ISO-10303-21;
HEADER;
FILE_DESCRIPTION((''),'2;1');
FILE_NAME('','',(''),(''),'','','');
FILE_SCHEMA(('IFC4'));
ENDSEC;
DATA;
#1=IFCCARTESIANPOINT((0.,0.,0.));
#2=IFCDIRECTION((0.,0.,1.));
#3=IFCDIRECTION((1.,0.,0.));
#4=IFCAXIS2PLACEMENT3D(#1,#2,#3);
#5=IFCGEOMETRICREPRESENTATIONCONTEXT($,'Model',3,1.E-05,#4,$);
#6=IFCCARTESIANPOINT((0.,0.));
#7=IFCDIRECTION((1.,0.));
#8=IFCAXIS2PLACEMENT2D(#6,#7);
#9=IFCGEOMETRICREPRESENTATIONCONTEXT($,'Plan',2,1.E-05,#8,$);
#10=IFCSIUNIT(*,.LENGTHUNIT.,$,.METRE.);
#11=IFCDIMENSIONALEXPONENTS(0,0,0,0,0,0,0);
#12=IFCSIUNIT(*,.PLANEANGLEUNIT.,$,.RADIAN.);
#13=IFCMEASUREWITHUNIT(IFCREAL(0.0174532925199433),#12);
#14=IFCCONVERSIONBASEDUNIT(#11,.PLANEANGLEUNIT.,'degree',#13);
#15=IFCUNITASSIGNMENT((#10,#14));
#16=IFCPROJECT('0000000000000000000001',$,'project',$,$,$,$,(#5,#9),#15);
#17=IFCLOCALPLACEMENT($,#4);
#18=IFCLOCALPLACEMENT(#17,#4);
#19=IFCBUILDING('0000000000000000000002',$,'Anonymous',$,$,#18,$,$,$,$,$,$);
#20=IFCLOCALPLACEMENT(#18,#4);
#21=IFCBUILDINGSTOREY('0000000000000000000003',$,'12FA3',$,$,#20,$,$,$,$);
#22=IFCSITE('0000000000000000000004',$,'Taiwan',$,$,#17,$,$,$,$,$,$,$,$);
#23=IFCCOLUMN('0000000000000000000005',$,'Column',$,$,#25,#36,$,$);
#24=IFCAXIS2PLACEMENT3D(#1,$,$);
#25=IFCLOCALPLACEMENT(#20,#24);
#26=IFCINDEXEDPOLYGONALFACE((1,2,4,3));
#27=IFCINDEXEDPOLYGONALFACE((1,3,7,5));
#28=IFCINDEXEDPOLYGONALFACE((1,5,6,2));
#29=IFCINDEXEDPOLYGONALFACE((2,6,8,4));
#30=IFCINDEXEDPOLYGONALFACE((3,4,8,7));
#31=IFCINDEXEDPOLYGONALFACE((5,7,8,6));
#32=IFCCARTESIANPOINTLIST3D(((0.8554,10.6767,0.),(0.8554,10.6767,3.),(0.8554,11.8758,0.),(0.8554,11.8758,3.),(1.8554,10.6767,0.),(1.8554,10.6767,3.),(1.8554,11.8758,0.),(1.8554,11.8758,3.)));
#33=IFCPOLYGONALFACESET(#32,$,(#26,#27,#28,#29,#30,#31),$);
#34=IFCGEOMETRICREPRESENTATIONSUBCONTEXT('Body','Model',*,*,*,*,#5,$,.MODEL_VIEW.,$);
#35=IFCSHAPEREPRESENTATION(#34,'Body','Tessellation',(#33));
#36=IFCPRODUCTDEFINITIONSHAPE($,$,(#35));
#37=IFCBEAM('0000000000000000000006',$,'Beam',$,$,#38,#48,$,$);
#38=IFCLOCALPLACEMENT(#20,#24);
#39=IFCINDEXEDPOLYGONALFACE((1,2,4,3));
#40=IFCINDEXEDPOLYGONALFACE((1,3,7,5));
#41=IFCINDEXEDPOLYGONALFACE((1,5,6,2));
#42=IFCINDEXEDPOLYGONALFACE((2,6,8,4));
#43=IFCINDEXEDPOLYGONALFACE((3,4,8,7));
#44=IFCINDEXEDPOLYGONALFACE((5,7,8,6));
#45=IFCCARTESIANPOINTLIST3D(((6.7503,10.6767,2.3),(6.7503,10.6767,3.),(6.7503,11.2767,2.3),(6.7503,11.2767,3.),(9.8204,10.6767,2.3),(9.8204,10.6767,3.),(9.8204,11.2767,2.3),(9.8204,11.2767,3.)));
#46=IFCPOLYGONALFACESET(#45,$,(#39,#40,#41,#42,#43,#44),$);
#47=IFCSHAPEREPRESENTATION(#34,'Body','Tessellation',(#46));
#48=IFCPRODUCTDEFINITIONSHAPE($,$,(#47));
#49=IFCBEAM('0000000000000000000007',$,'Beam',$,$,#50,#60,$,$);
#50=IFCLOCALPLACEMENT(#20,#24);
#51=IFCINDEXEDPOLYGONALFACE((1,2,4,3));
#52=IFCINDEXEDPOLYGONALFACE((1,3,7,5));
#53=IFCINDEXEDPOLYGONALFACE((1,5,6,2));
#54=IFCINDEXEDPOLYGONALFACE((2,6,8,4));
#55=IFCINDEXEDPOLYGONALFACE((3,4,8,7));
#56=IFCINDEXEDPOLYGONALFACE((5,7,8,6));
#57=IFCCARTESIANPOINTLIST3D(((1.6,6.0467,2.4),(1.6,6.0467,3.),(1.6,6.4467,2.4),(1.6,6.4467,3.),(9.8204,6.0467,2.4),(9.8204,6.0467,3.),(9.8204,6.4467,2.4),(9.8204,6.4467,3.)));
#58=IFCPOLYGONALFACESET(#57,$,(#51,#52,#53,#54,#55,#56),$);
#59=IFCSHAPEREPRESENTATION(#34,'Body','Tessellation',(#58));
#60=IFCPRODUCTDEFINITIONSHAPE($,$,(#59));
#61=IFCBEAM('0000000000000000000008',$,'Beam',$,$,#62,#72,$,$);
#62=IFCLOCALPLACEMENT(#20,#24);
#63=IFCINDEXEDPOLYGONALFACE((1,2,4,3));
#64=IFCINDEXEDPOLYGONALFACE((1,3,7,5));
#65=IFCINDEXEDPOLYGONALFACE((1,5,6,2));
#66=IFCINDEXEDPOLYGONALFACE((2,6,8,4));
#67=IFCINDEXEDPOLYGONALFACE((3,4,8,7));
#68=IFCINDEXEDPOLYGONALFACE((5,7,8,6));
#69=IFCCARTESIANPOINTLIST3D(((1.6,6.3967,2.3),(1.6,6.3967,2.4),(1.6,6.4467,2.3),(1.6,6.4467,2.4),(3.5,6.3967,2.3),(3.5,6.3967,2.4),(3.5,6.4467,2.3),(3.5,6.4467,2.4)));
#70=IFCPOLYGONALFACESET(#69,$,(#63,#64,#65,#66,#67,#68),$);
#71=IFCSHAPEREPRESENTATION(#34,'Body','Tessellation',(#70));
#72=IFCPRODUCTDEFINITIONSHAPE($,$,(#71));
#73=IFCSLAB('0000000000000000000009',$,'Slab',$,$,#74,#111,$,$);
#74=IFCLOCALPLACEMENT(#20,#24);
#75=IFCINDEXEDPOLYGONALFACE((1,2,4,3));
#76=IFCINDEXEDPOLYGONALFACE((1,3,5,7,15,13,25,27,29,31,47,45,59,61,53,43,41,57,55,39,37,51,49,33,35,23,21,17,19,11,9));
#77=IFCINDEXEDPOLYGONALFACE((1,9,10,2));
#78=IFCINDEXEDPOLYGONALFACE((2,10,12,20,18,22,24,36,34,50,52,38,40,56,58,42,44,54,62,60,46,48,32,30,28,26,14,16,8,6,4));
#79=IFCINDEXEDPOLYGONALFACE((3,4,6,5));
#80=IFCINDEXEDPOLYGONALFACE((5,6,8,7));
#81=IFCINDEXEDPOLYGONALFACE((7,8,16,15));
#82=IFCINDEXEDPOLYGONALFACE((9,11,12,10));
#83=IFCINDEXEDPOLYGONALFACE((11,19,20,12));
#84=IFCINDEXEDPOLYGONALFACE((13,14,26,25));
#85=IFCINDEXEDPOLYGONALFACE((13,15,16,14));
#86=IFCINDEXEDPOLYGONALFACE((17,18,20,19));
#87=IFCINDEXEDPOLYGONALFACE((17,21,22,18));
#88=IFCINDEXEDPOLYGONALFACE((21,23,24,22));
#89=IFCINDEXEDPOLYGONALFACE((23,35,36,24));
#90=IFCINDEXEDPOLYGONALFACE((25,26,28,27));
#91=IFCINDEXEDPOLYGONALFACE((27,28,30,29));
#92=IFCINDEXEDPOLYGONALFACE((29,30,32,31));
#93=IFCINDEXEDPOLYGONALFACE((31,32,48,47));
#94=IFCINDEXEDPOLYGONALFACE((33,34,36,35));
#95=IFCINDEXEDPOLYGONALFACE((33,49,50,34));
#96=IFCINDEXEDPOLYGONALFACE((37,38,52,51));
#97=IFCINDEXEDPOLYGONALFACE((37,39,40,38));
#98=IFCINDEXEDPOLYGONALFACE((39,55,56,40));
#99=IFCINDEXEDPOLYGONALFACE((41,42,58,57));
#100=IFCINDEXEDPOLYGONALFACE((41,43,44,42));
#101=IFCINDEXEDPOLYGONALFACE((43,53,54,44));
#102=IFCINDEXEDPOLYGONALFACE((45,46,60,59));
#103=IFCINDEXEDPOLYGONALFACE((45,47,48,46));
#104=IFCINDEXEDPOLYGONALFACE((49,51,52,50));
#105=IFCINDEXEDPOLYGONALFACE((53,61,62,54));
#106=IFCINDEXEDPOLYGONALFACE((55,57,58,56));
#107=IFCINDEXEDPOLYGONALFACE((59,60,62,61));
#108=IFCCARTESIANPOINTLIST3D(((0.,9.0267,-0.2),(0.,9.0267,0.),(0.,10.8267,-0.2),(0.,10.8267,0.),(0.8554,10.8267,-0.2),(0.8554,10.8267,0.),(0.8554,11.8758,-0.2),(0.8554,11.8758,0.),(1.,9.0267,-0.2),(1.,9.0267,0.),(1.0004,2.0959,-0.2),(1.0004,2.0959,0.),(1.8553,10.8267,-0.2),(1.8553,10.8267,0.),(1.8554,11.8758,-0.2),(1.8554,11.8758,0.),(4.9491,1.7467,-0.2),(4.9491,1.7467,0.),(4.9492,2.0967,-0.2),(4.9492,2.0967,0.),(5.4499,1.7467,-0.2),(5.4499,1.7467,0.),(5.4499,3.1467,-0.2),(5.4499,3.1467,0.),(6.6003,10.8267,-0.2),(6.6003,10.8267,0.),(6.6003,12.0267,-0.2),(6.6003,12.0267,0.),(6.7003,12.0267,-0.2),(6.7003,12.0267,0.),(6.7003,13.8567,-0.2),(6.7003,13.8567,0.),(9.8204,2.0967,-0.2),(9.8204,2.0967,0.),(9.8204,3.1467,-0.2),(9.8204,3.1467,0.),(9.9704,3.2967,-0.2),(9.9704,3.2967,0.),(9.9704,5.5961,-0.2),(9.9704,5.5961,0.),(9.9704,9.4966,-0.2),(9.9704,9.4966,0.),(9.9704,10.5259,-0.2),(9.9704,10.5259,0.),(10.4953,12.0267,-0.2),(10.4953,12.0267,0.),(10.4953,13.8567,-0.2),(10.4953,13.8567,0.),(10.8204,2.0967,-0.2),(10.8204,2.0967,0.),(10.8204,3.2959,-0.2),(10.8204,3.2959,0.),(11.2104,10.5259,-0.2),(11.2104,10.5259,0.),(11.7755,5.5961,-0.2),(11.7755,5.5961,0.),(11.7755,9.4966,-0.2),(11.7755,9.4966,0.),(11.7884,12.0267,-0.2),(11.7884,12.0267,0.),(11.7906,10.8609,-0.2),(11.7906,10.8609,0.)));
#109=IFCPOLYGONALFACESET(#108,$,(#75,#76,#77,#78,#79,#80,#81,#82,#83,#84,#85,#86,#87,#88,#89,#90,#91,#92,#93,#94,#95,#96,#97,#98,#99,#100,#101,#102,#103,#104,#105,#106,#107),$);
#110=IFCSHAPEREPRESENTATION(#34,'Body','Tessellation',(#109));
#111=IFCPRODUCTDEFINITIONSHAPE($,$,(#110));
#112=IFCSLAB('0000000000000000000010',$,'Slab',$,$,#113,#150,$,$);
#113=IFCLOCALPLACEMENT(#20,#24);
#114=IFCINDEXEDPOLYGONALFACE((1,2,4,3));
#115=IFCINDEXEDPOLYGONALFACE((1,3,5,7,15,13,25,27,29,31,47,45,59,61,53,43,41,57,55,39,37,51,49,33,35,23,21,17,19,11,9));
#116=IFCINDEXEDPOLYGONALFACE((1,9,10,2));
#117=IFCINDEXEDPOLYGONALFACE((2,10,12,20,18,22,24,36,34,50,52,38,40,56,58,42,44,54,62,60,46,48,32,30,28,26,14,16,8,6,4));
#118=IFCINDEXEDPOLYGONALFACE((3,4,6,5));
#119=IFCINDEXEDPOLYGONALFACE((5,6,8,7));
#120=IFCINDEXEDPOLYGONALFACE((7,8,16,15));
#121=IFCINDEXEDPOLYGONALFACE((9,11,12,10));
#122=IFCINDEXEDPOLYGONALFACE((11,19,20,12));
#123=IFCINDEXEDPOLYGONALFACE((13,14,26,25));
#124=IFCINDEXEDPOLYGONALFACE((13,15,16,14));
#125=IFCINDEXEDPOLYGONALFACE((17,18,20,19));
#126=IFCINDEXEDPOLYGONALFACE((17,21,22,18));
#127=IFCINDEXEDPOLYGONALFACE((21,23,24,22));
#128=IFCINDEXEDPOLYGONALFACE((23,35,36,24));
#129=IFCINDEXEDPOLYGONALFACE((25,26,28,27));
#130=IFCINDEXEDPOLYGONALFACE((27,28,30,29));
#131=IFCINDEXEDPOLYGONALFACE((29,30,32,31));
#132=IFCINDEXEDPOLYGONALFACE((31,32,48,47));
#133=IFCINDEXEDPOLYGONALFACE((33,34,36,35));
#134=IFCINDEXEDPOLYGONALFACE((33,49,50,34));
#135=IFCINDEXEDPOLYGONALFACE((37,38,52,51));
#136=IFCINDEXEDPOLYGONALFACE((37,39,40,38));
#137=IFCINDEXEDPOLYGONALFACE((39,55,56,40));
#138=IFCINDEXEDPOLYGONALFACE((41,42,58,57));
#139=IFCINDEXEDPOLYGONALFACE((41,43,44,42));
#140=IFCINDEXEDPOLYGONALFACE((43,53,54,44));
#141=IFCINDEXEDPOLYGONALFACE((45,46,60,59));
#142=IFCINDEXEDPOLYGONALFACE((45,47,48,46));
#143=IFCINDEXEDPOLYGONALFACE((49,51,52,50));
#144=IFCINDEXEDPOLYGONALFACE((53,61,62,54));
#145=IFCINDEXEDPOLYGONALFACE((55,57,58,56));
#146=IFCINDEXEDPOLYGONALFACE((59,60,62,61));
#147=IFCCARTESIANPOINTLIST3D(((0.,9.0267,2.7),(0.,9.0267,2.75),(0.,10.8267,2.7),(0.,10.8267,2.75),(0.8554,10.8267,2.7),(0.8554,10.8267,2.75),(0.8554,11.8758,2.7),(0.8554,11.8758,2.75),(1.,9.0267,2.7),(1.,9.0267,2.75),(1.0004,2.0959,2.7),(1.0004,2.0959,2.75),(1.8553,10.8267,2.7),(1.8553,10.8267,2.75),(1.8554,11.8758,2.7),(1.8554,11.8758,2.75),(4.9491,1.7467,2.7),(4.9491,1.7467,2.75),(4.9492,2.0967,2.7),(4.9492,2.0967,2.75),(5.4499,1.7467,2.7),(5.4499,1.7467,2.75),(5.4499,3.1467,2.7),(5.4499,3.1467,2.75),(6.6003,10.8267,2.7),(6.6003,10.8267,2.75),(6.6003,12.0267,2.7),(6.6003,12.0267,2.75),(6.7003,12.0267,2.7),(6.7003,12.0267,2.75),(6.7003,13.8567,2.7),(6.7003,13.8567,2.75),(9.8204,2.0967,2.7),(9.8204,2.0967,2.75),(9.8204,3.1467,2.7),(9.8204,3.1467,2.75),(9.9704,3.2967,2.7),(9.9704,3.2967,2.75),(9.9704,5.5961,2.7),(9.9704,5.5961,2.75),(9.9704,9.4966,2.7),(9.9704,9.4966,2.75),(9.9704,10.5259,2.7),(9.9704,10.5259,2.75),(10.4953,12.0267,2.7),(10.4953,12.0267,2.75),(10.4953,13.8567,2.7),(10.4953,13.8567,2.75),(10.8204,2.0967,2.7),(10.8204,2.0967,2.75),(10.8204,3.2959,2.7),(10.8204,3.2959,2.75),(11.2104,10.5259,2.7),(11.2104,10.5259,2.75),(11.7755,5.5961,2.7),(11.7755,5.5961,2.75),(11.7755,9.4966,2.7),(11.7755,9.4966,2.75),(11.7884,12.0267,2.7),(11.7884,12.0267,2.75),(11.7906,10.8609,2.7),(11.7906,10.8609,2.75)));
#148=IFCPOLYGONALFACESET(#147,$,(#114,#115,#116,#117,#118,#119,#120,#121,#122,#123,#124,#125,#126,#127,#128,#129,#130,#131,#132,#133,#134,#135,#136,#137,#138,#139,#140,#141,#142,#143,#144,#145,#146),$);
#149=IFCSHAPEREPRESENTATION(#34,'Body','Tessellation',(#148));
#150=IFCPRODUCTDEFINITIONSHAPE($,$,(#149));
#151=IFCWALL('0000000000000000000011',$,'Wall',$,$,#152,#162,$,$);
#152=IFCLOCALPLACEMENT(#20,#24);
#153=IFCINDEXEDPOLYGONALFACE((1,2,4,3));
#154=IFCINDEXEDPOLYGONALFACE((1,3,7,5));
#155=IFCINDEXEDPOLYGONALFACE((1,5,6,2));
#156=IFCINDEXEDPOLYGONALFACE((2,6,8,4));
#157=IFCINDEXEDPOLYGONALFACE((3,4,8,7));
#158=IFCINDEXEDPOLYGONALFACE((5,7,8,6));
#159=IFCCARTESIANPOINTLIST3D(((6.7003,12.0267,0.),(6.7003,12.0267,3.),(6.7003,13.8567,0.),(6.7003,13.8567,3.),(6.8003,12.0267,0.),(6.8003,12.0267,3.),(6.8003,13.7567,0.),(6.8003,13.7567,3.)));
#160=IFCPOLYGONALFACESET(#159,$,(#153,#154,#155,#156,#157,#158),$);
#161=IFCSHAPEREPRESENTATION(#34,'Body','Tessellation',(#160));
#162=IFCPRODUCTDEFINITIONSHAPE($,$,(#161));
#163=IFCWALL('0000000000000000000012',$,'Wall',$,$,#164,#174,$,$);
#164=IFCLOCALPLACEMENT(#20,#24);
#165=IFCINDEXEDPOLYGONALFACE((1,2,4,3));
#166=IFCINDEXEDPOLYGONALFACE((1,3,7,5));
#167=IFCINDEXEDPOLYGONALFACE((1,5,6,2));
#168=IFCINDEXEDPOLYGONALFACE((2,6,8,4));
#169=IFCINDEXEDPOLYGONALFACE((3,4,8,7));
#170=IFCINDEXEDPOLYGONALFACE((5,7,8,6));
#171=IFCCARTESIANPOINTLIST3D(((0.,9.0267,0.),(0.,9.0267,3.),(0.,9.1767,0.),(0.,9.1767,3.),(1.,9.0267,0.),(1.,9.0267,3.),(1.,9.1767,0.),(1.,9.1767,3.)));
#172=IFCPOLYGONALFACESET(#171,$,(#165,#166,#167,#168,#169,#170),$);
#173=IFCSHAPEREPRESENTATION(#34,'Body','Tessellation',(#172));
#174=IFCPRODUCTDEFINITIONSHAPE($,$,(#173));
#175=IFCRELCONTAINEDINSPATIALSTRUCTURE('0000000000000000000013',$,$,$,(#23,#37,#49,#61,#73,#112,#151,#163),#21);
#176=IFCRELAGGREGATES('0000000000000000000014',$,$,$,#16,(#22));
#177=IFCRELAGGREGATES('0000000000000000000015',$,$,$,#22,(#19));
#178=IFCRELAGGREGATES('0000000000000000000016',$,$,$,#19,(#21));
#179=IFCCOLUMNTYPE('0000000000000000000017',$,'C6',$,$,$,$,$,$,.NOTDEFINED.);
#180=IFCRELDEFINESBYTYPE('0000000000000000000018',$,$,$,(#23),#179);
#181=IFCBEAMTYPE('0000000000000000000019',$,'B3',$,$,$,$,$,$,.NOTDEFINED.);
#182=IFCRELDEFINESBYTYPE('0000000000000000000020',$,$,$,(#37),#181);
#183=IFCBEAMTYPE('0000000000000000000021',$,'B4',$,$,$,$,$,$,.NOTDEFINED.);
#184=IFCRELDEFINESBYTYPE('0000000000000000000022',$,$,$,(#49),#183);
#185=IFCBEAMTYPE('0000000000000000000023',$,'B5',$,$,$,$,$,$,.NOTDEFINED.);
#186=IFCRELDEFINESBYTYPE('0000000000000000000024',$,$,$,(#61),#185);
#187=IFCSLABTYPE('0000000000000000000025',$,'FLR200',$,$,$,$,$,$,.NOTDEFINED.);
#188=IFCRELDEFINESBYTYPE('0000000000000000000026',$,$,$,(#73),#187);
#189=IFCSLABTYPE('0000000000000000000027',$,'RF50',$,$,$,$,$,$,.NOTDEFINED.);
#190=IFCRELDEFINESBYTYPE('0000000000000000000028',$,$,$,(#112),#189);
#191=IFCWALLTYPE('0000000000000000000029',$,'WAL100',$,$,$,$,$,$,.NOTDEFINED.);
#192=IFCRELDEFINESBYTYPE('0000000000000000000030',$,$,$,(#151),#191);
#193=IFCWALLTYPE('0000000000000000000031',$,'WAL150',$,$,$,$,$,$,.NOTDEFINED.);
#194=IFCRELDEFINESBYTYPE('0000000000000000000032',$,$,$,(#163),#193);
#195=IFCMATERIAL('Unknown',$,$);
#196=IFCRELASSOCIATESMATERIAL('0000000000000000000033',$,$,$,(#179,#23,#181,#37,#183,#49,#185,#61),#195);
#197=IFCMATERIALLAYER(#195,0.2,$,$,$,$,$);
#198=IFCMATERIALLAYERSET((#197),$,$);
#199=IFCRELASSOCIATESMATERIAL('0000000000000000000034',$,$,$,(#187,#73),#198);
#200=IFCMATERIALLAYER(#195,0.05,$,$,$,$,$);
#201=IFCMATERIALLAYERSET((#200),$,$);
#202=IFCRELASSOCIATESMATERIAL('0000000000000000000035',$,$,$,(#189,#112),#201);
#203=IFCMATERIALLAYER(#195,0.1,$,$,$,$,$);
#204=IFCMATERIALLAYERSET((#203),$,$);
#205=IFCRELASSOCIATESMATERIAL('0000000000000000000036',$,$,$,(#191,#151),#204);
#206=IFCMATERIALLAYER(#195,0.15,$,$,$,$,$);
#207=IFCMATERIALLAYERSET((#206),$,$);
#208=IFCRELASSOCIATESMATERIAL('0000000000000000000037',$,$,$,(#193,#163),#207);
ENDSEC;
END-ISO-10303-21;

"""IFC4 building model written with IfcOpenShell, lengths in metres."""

from ifc_helpers import new_model, entity, si_unit, converted_unit, frame, origin_with_axes, origin_2d_with_axis, place, context, subcontext, project, spatial, line, indexed_curve, rectangle, outline, extrude, material, layer, layer_set, layer_usage, material_profile, profile_set, profile_usage, type_object, element, save


model = new_model("IFC4")

# Units and contexts
model_context = context("Model", 3, precision=1e-05, world=origin_with_axes())
plan_context = context("Plan", 2, precision=1e-05, world=origin_2d_with_axis())
body_context_1 = subcontext(model_context, "Body", "Model", "MODEL_VIEW")
ifc_project = project(units=[si_unit("LENGTHUNIT", "METRE"), converted_unit("PLANEANGLEUNIT", "degree", entity("IfcReal", 0.0174532925199433), si_unit("PLANEANGLEUNIT", "RADIAN"), dimensions=[0, 0, 0, 0, 0, 0, 0])], contexts=[model_context, plan_context])

# Site, building, storey
site_placement = place(None, origin_with_axes())
site = spatial("IfcSite", under=ifc_project, at=site_placement, Name="Taiwan")
building_placement = place(site_placement, origin_with_axes())
building = spatial("IfcBuilding", under=site, at=building_placement, Name="Anonymous")
storey_placement = place(building_placement, origin_with_axes())
storey = spatial("IfcBuildingStorey", under=building, at=storey_placement, Name="12FA3")

# Column
ifc_material = material(Name="Unknown")
ifc_material_profile_1 = material_profile(ifc_material, outline(indexed_curve([(0.0, 1.1992), (1.0, 1.1992), (1.0, 0.0), (0.0, 0.0), (0.0, 1.1992)])))
ifc_profile_set_1 = profile_set([ifc_material_profile_1])
ifc_profile_usage_1 = profile_usage(ifc_profile_set_1, cardinal=5)
column_type = type_object("IfcColumnType", Name="C6", PredefinedType="NOTDEFINED", material=ifc_profile_set_1)
column_placement = place(storey_placement, frame((0.8554, 10.6767, 0.0), z_axis=(0.0, 0.0, 1.0), x_axis=(1.0, 0.0, 0.0)))
element("IfcColumn", 1, at=column_placement, inside=storey, type_object=column_type, material=ifc_profile_usage_1, Name="Column", context=body_context_1, shape_type="SweptSolid", body=[
    extrude(outline(indexed_curve([(0.0, 1.1992), (1.0, 1.1992), (1.0, 0.0), (0.0, 0.0), (0.0, 1.1992)])), origin_with_axes(), (0.0, 0.0, 1.0), 3.0),
])

# Beams
ifc_material_profile_2 = material_profile(ifc_material, rectangle(XDim=0.6, YDim=0.7, kind="CURVE"))
ifc_profile_set_2 = profile_set([ifc_material_profile_2])
ifc_profile_usage_2 = profile_usage(ifc_profile_set_2, cardinal=9)
beam_type_1 = type_object("IfcBeamType", Name="B3", PredefinedType="NOTDEFINED", material=ifc_profile_set_2)
beam_1_placement = place(storey_placement, frame((6.7503, 10.6767, 3.0), z_axis=(1.0, 0.0, 0.0), x_axis=(0.0, 1.0, 0.0)))
element("IfcBeam", 2, at=beam_1_placement, inside=storey, type_object=beam_type_1, material=ifc_profile_usage_2, Name="Beam", context=body_context_1, shape_type="SweptSolid", body=[
    extrude(rectangle(XDim=0.6, YDim=0.7, kind="CURVE"), frame((0.3, -0.35, 0.0), z_axis=(0.0, 0.0, 1.0), x_axis=(1.0, 0.0, 0.0)), (0.0, 0.0, 1.0), 3.0701),
])
ifc_material_profile_3 = material_profile(ifc_material, rectangle(XDim=0.4, YDim=0.6, kind="CURVE"))
ifc_profile_set_3 = profile_set([ifc_material_profile_3])
ifc_profile_usage_3 = profile_usage(ifc_profile_set_3, cardinal=7)
beam_type_2 = type_object("IfcBeamType", Name="B4", PredefinedType="NOTDEFINED", material=ifc_profile_set_3)
beam_2_placement = place(storey_placement, frame((1.6, 6.4467, 3.0), z_axis=(1.0, 0.0, 0.0), x_axis=(0.0, 1.0, 0.0)))
element("IfcBeam", 3, at=beam_2_placement, inside=storey, type_object=beam_type_2, material=ifc_profile_usage_3, Name="Beam", context=body_context_1, shape_type="SweptSolid", body=[
    extrude(rectangle(XDim=0.4, YDim=0.6, kind="CURVE"), frame((-0.2, -0.3, 0.0), z_axis=(0.0, 0.0, 1.0), x_axis=(1.0, 0.0, 0.0)), (0.0, 0.0, 1.0), 8.2203),
])
ifc_material_profile_4 = material_profile(ifc_material, rectangle(XDim=0.05, YDim=0.1, kind="CURVE"))
ifc_profile_set_4 = profile_set([ifc_material_profile_4])
ifc_profile_usage_4 = profile_usage(ifc_profile_set_4, cardinal=3)
beam_type_3 = type_object("IfcBeamType", Name="B5", PredefinedType="NOTDEFINED", material=ifc_profile_set_4)
beam_3_placement = place(storey_placement, frame((3.5, 6.4467, 2.3), z_axis=(-1.0, -0.000001, 0.000001), x_axis=(0.000001, -1.0, 0.0)))
element("IfcBeam", 4, at=beam_3_placement, inside=storey, type_object=beam_type_3, material=ifc_profile_usage_4, Name="Beam", context=body_context_1, shape_type="SweptSolid", body=[
    extrude(rectangle(XDim=0.05, YDim=0.1, kind="CURVE"), frame((0.025, 0.05, 0.0), z_axis=(0.0, 0.0, 1.0), x_axis=(1.0, 0.0, 0.0)), (0.0, 0.0, 1.0), 1.9),
])

# Slabs
ifc_layer_1 = layer(ifc_material, 0.2)
ifc_layer_set_1 = layer_set([ifc_layer_1])
ifc_layer_usage_1 = layer_usage(ifc_layer_set_1, "AXIS3", "POSITIVE", -0.2)
slab_type_1 = type_object("IfcSlabType", Name="FLR200", PredefinedType="NOTDEFINED", material=ifc_layer_set_1)
slab_1_placement = place(storey_placement, frame((0.0, 10.8267, 0.0), z_axis=(0.0, 0.0, 1.0), x_axis=(1.0, 0.0, 0.0)))
element("IfcSlab", 5, at=slab_1_placement, inside=storey, type_object=slab_type_1, material=ifc_layer_usage_1, Name="Slab", context=body_context_1, shape_type="SweptSolid", body=[
    extrude(outline(indexed_curve([(0.0, 0.0), (0.0, -1.8), (1.0, -1.8), (1.0004, -8.7308), (4.9492, -8.73), (4.9491, -9.08), (5.4499, -9.08), (5.4499, -7.68), (9.8203, -7.68), (9.8203, -8.73), (10.8203, -8.73), (10.8203, -7.5308), (9.9703, -7.53), (9.9703, -5.2306), (11.7754, -5.2306), (11.7754, -1.3301), (9.9703, -1.3301), (9.9703, -0.3008), (11.2103, -0.3008), (11.7906, 0.0342), (11.7884, 1.2), (10.4952, 1.2), (10.4952, 3.03), (6.7002, 3.03), (6.7002, 1.2001), (6.6003, 1.2), (6.6003, 0.0), (1.8552, 0.0), (1.8553, 1.0492), (0.8553, 1.0492), (0.8553, 0.0), (0.0, 0.0)])), frame((0.0, 0.0, -0.2), z_axis=(0.0, 0.0, 1.0), x_axis=(1.0, 0.0, 0.0)), (0.0, 0.0, 1.0), 0.2),
])
ifc_layer_2 = layer(ifc_material, 0.05)
ifc_layer_set_2 = layer_set([ifc_layer_2])
ifc_layer_usage_2 = layer_usage(ifc_layer_set_2, "AXIS3", "POSITIVE", 0.0)
slab_type_2 = type_object("IfcSlabType", Name="RF50", PredefinedType="NOTDEFINED", material=ifc_layer_set_2)
slab_2_placement = place(storey_placement, frame((0.0, 10.8267, 2.7), z_axis=(0.0, 0.0, 1.0), x_axis=(1.0, 0.0, 0.0)))
element("IfcSlab", 6, at=slab_2_placement, inside=storey, type_object=slab_type_2, material=ifc_layer_usage_2, Name="Slab", context=body_context_1, shape_type="SweptSolid", body=[
    extrude(outline(indexed_curve([(0.0, 0.0), (0.0, -1.8), (1.0, -1.8), (1.0004, -8.7308), (4.9492, -8.73), (4.9491, -9.08), (5.4499, -9.08), (5.4499, -7.68), (9.8203, -7.68), (9.8203, -8.73), (10.8203, -8.73), (10.8203, -7.5308), (9.9703, -7.53), (9.9703, -5.2306), (11.7754, -5.2306), (11.7754, -1.3301), (9.9703, -1.3301), (9.9703, -0.3008), (11.2103, -0.3008), (11.7906, 0.0342), (11.7884, 1.2), (10.4952, 1.2), (10.4952, 3.03), (6.7002, 3.03), (6.7002, 1.2001), (6.6003, 1.2), (6.6003, 0.0), (1.8552, 0.0), (1.8553, 1.0492), (0.8553, 1.0492), (0.8553, 0.0), (0.0, 0.0)])), None, (0.0, 0.0, 1.0), 0.05),
])

# Walls
ifc_layer_3 = layer(ifc_material, 0.1)
ifc_layer_set_3 = layer_set([ifc_layer_3])
ifc_layer_usage_3 = layer_usage(ifc_layer_set_3, "AXIS2", "POSITIVE", 0.0)
wall_type_1 = type_object("IfcWallType", Name="WAL100", PredefinedType="NOTDEFINED", material=ifc_layer_set_3)
wall_1_placement = place(storey_placement, frame((6.7003, 13.8567, 0.0), z_axis=(0.0, 0.0, 1.0), x_axis=(0.0, -1.0, 0.0)))
element("IfcWall", 7, at=wall_1_placement, inside=storey, type_object=wall_type_1, material=ifc_layer_usage_3, Name="Wall", context=body_context_1, shape_type="SweptSolid", body=[
    extrude(outline(indexed_curve([(0.0, 0.0), (0.1, 0.1), (1.8299, 0.1), (1.8299, 0.0)], segments=[line(1, 2, 3, 4, 1)])), origin_with_axes(), (0.0, 0.0, 1.0), 3.0),
])
ifc_layer_4 = layer(ifc_material, 0.15)
ifc_layer_set_4 = layer_set([ifc_layer_4])
ifc_layer_usage_4 = layer_usage(ifc_layer_set_4, "AXIS2", "POSITIVE", 0.0)
wall_type_2 = type_object("IfcWallType", Name="WAL150", PredefinedType="NOTDEFINED", material=ifc_layer_set_4)
wall_2_placement = place(storey_placement, frame((0.0, 9.0267, 0.0), z_axis=(0.0, 0.0, 1.0), x_axis=(1.0, 0.0, 0.0)))
element("IfcWall", 8, at=wall_2_placement, inside=storey, type_object=wall_type_2, material=ifc_layer_usage_4, Name="Wall", context=body_context_1, shape_type="SweptSolid", body=[
    extrude(outline(indexed_curve([(0.0, 0.0), (0.0, 0.15), (1.0, 0.15), (1.0, 0.0)], segments=[line(1, 2, 3, 4, 1)])), origin_with_axes(), (0.0, 0.0, 1.0), 3.0),
])

save(model, "model.ifc")
